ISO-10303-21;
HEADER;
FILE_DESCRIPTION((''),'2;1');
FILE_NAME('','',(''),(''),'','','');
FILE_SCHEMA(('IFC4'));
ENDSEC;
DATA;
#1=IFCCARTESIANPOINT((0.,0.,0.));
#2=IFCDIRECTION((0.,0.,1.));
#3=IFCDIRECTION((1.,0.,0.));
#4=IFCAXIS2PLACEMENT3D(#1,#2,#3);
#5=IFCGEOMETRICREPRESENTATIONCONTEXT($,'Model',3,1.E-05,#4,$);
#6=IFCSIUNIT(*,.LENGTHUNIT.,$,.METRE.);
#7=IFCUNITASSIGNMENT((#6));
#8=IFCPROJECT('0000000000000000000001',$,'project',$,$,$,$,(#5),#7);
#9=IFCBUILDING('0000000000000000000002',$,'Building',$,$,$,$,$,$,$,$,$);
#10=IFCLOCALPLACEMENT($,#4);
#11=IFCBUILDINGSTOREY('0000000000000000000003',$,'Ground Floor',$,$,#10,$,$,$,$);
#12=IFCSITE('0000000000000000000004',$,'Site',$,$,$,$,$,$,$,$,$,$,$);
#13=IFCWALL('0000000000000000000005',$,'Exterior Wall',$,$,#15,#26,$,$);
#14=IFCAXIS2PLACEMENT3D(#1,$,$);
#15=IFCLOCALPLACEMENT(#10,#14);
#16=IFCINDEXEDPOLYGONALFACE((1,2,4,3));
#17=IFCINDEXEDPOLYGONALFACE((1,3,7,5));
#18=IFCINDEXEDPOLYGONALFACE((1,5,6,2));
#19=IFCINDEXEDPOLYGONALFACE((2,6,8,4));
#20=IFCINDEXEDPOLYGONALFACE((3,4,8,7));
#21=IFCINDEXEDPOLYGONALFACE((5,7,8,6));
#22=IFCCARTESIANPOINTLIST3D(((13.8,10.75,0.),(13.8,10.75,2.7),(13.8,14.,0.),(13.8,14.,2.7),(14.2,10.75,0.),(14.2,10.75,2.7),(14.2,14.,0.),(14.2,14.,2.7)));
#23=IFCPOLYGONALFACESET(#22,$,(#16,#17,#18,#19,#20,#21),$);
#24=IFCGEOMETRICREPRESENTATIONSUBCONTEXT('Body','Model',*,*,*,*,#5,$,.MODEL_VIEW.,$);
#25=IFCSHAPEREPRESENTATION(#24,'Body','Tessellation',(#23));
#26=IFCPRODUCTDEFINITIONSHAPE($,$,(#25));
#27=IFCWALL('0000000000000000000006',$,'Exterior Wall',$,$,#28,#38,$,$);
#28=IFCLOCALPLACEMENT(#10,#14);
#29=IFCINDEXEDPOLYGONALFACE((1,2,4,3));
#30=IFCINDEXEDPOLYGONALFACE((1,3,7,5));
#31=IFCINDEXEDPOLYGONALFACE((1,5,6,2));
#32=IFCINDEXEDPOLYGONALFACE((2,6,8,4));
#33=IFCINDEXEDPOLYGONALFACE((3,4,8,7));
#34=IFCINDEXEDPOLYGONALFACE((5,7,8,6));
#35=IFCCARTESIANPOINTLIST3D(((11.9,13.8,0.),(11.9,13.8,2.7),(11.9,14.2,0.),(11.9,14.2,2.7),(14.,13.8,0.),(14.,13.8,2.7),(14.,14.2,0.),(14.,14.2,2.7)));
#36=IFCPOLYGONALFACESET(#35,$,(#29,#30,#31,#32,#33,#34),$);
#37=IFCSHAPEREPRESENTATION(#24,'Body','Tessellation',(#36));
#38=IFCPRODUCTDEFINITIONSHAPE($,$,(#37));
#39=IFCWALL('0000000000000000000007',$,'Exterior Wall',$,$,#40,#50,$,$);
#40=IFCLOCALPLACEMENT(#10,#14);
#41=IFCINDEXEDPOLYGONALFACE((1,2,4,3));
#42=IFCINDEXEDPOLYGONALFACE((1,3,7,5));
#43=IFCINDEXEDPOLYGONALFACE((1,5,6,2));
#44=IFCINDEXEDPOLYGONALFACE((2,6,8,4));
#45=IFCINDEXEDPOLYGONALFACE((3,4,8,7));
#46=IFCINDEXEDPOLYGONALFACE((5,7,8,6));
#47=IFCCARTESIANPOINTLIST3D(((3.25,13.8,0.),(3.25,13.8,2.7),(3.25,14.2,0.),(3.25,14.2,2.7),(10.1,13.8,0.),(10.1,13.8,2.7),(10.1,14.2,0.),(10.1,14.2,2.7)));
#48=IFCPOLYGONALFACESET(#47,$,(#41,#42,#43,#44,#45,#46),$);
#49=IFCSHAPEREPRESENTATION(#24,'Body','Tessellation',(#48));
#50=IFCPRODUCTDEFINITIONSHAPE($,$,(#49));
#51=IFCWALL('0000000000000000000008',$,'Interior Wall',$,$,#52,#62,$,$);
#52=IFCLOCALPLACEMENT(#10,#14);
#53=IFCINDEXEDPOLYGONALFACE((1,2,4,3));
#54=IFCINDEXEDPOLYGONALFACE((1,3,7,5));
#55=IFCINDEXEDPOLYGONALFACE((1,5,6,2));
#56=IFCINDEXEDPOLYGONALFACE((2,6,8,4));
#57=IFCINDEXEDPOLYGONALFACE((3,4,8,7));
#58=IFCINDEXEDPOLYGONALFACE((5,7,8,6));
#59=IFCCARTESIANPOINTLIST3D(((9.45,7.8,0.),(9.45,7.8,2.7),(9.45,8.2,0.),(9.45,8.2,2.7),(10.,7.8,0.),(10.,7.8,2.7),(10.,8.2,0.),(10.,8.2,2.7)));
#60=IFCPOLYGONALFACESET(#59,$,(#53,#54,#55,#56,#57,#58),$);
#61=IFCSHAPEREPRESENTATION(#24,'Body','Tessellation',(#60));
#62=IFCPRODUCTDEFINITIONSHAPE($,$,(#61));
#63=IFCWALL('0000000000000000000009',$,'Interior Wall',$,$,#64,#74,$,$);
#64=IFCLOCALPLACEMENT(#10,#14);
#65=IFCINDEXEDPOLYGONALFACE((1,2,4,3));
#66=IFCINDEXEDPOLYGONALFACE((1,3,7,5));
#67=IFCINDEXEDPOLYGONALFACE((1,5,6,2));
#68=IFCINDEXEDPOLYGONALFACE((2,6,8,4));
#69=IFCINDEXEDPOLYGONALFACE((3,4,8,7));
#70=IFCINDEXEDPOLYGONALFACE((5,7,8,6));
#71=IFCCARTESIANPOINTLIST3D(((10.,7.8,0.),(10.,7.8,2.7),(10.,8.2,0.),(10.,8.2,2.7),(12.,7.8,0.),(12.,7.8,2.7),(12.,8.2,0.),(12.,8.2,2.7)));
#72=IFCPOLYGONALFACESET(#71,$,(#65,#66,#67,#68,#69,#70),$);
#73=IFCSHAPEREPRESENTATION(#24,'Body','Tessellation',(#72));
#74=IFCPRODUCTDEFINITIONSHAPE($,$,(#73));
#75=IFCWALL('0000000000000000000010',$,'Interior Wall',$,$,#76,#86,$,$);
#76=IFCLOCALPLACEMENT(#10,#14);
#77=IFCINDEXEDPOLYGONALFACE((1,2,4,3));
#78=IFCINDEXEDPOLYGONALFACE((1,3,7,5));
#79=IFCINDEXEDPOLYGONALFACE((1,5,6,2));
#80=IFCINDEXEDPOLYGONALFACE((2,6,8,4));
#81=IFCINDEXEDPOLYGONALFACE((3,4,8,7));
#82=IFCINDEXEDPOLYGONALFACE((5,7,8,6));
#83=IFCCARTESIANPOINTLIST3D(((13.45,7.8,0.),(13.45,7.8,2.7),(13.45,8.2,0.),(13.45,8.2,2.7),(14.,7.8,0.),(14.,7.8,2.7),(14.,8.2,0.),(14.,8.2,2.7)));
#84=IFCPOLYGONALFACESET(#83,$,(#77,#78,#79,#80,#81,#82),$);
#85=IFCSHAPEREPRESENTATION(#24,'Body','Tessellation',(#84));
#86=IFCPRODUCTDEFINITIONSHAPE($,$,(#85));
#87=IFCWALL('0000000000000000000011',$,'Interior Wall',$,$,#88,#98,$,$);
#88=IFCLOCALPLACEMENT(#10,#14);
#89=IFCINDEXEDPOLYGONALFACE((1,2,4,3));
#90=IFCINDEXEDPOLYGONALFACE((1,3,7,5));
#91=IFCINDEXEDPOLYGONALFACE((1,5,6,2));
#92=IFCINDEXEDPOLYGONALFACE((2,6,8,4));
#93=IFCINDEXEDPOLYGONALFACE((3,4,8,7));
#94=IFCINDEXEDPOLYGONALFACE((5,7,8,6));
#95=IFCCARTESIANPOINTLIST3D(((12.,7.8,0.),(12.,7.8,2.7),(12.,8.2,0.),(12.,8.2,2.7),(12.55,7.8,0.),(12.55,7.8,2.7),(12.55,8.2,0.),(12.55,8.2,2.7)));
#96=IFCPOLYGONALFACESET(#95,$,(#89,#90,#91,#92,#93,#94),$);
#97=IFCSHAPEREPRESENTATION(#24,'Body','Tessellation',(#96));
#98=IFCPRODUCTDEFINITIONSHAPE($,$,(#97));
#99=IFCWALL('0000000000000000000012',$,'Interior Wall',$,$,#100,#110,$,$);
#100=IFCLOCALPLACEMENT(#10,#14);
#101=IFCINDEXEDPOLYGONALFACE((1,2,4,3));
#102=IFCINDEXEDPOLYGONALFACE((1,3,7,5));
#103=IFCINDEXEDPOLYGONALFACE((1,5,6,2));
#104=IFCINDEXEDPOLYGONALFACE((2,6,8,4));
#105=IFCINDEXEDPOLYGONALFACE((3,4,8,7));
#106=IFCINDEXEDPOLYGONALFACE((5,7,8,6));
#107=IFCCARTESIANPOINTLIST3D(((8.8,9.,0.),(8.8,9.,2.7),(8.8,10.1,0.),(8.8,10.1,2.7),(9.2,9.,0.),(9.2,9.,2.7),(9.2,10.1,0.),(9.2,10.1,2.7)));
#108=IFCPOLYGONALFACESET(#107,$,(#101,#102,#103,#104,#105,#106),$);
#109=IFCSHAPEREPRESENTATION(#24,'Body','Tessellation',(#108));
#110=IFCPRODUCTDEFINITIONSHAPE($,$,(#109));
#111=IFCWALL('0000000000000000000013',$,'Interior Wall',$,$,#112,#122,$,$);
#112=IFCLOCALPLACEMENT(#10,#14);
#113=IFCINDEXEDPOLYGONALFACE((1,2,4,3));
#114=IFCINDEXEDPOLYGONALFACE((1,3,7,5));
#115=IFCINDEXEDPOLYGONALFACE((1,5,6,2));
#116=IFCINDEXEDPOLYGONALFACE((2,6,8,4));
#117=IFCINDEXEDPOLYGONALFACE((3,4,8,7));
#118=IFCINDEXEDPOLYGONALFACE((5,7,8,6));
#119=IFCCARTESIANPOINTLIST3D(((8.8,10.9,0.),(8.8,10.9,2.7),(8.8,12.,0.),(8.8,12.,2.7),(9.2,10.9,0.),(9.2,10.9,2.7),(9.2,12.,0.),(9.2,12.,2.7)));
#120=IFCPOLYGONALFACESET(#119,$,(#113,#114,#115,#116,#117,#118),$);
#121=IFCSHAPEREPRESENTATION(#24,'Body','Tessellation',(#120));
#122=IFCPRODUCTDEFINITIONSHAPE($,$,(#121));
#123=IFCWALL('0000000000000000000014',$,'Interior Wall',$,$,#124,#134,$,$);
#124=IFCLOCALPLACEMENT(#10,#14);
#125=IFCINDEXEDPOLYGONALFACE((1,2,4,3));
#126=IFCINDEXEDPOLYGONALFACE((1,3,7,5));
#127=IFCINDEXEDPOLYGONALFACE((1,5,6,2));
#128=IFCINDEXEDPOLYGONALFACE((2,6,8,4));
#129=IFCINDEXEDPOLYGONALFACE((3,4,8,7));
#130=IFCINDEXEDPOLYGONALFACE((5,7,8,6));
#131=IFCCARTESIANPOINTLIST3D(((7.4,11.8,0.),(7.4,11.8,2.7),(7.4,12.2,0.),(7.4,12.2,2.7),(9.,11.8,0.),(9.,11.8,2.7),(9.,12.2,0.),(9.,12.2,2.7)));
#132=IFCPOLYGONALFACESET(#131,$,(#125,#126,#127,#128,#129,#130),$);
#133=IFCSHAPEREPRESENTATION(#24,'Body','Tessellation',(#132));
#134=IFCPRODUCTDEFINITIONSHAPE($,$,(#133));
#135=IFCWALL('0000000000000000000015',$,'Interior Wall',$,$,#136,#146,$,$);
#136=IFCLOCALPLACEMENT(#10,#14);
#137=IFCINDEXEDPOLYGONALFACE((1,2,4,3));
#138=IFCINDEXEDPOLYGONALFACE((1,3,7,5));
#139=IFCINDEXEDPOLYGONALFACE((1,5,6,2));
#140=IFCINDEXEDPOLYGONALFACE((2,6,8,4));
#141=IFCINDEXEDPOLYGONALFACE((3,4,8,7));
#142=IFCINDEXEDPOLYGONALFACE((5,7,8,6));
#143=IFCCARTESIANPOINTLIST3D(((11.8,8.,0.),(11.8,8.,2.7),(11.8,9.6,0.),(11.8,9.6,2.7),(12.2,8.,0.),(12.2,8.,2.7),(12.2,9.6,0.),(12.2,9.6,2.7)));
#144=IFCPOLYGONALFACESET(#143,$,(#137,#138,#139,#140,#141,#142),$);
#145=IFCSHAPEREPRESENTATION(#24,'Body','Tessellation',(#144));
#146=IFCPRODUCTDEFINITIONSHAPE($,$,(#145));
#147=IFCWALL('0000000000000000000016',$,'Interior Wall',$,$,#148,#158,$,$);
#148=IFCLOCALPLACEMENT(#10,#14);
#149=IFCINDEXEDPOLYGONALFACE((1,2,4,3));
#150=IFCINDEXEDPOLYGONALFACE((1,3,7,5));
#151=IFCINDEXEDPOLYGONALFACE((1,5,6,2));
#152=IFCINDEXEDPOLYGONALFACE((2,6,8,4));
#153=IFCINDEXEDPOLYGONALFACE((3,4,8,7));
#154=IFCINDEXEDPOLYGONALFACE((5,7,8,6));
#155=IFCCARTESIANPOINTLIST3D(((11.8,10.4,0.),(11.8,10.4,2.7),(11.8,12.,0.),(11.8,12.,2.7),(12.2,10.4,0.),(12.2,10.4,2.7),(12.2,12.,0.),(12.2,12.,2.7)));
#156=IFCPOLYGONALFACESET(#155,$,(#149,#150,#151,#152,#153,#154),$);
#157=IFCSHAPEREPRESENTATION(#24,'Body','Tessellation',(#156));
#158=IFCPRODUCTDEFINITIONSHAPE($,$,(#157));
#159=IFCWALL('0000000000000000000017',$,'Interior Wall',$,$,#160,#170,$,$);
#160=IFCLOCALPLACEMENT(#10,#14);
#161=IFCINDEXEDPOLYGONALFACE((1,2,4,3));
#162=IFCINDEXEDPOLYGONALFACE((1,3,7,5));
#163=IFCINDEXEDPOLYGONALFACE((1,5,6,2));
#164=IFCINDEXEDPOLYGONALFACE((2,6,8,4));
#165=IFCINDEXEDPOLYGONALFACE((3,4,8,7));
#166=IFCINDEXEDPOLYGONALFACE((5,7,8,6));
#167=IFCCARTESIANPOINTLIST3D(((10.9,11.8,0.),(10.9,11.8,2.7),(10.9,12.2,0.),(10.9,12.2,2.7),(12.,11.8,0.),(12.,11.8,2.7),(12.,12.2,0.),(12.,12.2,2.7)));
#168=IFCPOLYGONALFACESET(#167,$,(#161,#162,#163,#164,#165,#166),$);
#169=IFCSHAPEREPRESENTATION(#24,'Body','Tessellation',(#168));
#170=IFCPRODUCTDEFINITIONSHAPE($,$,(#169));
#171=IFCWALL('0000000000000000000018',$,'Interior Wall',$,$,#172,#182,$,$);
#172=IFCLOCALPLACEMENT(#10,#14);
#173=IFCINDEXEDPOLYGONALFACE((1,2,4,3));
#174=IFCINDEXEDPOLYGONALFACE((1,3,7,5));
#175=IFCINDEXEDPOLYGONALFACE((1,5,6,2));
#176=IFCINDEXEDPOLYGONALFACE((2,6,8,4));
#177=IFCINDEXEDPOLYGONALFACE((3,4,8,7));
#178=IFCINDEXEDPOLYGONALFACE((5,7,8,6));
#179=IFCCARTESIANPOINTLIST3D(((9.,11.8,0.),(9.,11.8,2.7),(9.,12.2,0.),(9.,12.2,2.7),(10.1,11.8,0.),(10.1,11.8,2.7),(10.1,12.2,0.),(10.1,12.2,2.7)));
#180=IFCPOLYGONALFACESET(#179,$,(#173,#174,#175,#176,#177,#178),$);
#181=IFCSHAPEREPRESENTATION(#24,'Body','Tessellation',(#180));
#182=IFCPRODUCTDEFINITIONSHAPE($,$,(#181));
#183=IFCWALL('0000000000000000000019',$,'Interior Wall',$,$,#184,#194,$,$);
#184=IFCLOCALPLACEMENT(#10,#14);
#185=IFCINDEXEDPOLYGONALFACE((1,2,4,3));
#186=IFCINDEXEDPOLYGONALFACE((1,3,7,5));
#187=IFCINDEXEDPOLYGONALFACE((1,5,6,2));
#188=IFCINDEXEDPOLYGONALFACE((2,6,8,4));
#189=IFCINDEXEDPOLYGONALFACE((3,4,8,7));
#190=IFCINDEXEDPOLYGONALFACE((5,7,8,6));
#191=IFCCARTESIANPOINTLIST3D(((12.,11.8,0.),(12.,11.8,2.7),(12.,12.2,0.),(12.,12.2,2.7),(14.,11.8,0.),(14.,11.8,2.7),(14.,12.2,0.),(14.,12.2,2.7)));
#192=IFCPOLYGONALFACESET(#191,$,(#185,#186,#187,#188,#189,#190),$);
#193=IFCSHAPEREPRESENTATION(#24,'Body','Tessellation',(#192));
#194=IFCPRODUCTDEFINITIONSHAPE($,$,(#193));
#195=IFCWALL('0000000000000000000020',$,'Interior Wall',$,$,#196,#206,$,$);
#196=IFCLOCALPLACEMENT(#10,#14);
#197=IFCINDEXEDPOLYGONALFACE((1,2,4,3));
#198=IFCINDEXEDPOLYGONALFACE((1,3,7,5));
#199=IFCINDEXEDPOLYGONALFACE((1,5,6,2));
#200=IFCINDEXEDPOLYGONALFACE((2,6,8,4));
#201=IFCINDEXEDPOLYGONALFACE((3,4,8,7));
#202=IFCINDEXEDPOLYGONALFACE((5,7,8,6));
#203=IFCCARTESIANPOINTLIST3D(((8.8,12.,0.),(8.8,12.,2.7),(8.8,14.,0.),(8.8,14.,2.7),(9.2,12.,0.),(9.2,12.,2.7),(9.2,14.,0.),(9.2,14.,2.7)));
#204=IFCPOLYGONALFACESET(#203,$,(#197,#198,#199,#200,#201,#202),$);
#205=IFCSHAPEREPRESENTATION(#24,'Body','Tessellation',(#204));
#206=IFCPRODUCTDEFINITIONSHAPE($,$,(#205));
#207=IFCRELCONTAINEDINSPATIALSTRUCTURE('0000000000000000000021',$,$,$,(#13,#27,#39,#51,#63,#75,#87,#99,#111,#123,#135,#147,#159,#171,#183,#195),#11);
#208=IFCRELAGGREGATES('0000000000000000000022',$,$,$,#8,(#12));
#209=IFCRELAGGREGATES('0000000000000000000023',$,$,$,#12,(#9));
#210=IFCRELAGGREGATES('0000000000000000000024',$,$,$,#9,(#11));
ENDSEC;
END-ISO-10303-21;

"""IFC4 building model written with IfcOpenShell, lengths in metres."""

from ifc_helpers import new_model, si_unit, frame, origin_with_axes, place, context, subcontext, project, spatial, indexed_curve, outline, extrude, element, save


model = new_model("IFC4")

# Units and contexts
model_context = context("Model", 3, precision=1e-05, world=origin_with_axes())
body_context = subcontext(model_context, "Body", "Model", "MODEL_VIEW")
ifc_project = project(units=[si_unit("LENGTHUNIT", "METRE")], contexts=[model_context])

# Site, building, storey
site = spatial("IfcSite", under=ifc_project, Name="Site")
building = spatial("IfcBuilding", under=site, Name="Building")
storey_placement = place(None, origin_with_axes())
storey = spatial("IfcBuildingStorey", under=building, at=storey_placement, Name="Ground Floor")

# Walls
wall_1_placement = place(storey_placement, frame((14.0, 10.75, 0.0), z_axis=(0.0, 0.0, 1.0), x_axis=(0.0, 1.0, 0.0)))
element("IfcWall", 1, at=wall_1_placement, inside=storey, Name="Exterior Wall", context=body_context, shape_type="SweptSolid", body=[
    extrude(outline(indexed_curve([(0.0, 0.0), (0.0, 0.4), (3.25, 0.4), (3.25, 0.0), (0.0, 0.0)], self_intersect=False)), frame((0.0, -0.2, 0.0), z_axis=(0.0, 0.0, 1.0), x_axis=(1.0, 0.0, 0.0)), (0.0, 0.0, 1.0), 2.7),
])
wall_2_placement = place(storey_placement, frame((14.0, 14.0, 0.0), z_axis=(0.0, 0.0, 1.0), x_axis=(-1.0, 0.0, 0.0)))
element("IfcWall", 2, at=wall_2_placement, inside=storey, Name="Exterior Wall", context=body_context, shape_type="SweptSolid", body=[
    extrude(outline(indexed_curve([(0.0, 0.0), (0.0, 0.4), (2.1, 0.4), (2.1, 0.0), (0.0, 0.0)], self_intersect=False)), frame((0.0, -0.2, 0.0), z_axis=(0.0, 0.0, 1.0), x_axis=(1.0, 0.0, 0.0)), (0.0, 0.0, 1.0), 2.7),
])
wall_3_placement = place(storey_placement, frame((10.1, 14.0, 0.0), z_axis=(0.0, 0.0, 1.0), x_axis=(-1.0, 0.0, 0.0)))
element("IfcWall", 3, at=wall_3_placement, inside=storey, Name="Exterior Wall", context=body_context, shape_type="SweptSolid", body=[
    extrude(outline(indexed_curve([(0.0, 0.0), (0.0, 0.4), (6.85, 0.4), (6.85, 0.0), (0.0, 0.0)], self_intersect=False)), frame((0.0, -0.2, 0.0), z_axis=(0.0, 0.0, 1.0), x_axis=(1.0, 0.0, 0.0)), (0.0, 0.0, 1.0), 2.7),
])
wall_4_placement = place(storey_placement, frame((10.0, 8.0, 0.0), z_axis=(0.0, 0.0, 1.0), x_axis=(-1.0, 0.0, 0.0)))
element("IfcWall", 4, at=wall_4_placement, inside=storey, Name="Interior Wall", context=body_context, shape_type="SweptSolid", body=[
    extrude(outline(indexed_curve([(0.0, 0.0), (0.0, 0.4), (0.55, 0.4), (0.55, 0.0), (0.0, 0.0)], self_intersect=False)), frame((0.0, -0.2, 0.0), z_axis=(0.0, 0.0, 1.0), x_axis=(1.0, 0.0, 0.0)), (0.0, 0.0, 1.0), 2.7),
])
wall_5_placement = place(storey_placement, frame((12.0, 8.0, 0.0), z_axis=(0.0, 0.0, 1.0), x_axis=(-1.0, 0.0, 0.0)))
element("IfcWall", 5, at=wall_5_placement, inside=storey, Name="Interior Wall", context=body_context, shape_type="SweptSolid", body=[
    extrude(outline(indexed_curve([(0.0, 0.0), (0.0, 0.4), (2.0, 0.4), (2.0, 0.0), (0.0, 0.0)], self_intersect=False)), frame((0.0, -0.2, 0.0), z_axis=(0.0, 0.0, 1.0), x_axis=(1.0, 0.0, 0.0)), (0.0, 0.0, 1.0), 2.7),
])
for number, where, z_axis, x_axis, name in (
    (6, (14.0, 8.0, 0.0), (0.0, 0.0, 1.0), (-1.0, 0.0, 0.0), "Interior Wall"),
    (7, (12.55, 8.0, 0.0), (0.0, 0.0, 1.0), (-1.0, 0.0, 0.0), "Interior Wall"),
):
    element("IfcWall", number, at=place(storey_placement, frame(where, z_axis=z_axis, x_axis=x_axis)), inside=storey, Name=name, context=body_context, shape_type="SweptSolid", body=[
        extrude(outline(indexed_curve([(0.0, 0.0), (0.0, 0.4), (0.55, 0.4), (0.55, 0.0), (0.0, 0.0)], self_intersect=False)), frame((0.0, -0.2, 0.0), z_axis=(0.0, 0.0, 1.0), x_axis=(1.0, 0.0, 0.0)), (0.0, 0.0, 1.0), 2.7),
    ])
for number, where, z_axis, x_axis, name in (
    (8, (9.0, 9.0, 0.0), (0.0, 0.0, 1.0), (0.0, 1.0, 0.0), "Interior Wall"),
    (9, (9.0, 10.9, 0.0), (0.0, 0.0, 1.0), (0.0, 1.0, 0.0), "Interior Wall"),
):
    element("IfcWall", number, at=place(storey_placement, frame(where, z_axis=z_axis, x_axis=x_axis)), inside=storey, Name=name, context=body_context, shape_type="SweptSolid", body=[
        extrude(outline(indexed_curve([(0.0, 0.0), (0.0, 0.4), (1.1, 0.4), (1.1, 0.0), (0.0, 0.0)], self_intersect=False)), frame((0.0, -0.2, 0.0), z_axis=(0.0, 0.0, 1.0), x_axis=(1.0, 0.0, 0.0)), (0.0, 0.0, 1.0), 2.7),
    ])
for number, where, z_axis, x_axis, name in (
    (10, (9.0, 12.0, 0.0), (0.0, 0.0, 1.0), (-1.0, 0.0, 0.0), "Interior Wall"),
    (11, (12.0, 8.0, 0.0), (0.0, 0.0, 1.0), (0.0, 1.0, 0.0), "Interior Wall"),
    (12, (12.0, 10.4, 0.0), (0.0, 0.0, 1.0), (0.0, 1.0, 0.0), "Interior Wall"),
):
    element("IfcWall", number, at=place(storey_placement, frame(where, z_axis=z_axis, x_axis=x_axis)), inside=storey, Name=name, context=body_context, shape_type="SweptSolid", body=[
        extrude(outline(indexed_curve([(0.0, 0.0), (0.0, 0.4), (1.6, 0.4), (1.6, 0.0), (0.0, 0.0)], self_intersect=False)), frame((0.0, -0.2, 0.0), z_axis=(0.0, 0.0, 1.0), x_axis=(1.0, 0.0, 0.0)), (0.0, 0.0, 1.0), 2.7),
    ])
for number, where, z_axis, x_axis, name in (
    (13, (12.0, 12.0, 0.0), (0.0, 0.0, 1.0), (-1.0, 0.0, 0.0), "Interior Wall"),
    (14, (10.1, 12.0, 0.0), (0.0, 0.0, 1.0), (-1.0, 0.0, 0.0), "Interior Wall"),
):
    element("IfcWall", number, at=place(storey_placement, frame(where, z_axis=z_axis, x_axis=x_axis)), inside=storey, Name=name, context=body_context, shape_type="SweptSolid", body=[
        extrude(outline(indexed_curve([(0.0, 0.0), (0.0, 0.4), (1.1, 0.4), (1.1, 0.0), (0.0, 0.0)], self_intersect=False)), frame((0.0, -0.2, 0.0), z_axis=(0.0, 0.0, 1.0), x_axis=(1.0, 0.0, 0.0)), (0.0, 0.0, 1.0), 2.7),
    ])
for number, where, z_axis, x_axis, name in (
    (15, (14.0, 12.0, 0.0), (0.0, 0.0, 1.0), (-1.0, 0.0, 0.0), "Interior Wall"),
    (16, (9.0, 12.0, 0.0), (0.0, 0.0, 1.0), (0.0, 1.0, 0.0), "Interior Wall"),
):
    element("IfcWall", number, at=place(storey_placement, frame(where, z_axis=z_axis, x_axis=x_axis)), inside=storey, Name=name, context=body_context, shape_type="SweptSolid", body=[
        extrude(outline(indexed_curve([(0.0, 0.0), (0.0, 0.4), (2.0, 0.4), (2.0, 0.0), (0.0, 0.0)], self_intersect=False)), frame((0.0, -0.2, 0.0), z_axis=(0.0, 0.0, 1.0), x_axis=(1.0, 0.0, 0.0)), (0.0, 0.0, 1.0), 2.7),
    ])

save(model, "model.ifc")
